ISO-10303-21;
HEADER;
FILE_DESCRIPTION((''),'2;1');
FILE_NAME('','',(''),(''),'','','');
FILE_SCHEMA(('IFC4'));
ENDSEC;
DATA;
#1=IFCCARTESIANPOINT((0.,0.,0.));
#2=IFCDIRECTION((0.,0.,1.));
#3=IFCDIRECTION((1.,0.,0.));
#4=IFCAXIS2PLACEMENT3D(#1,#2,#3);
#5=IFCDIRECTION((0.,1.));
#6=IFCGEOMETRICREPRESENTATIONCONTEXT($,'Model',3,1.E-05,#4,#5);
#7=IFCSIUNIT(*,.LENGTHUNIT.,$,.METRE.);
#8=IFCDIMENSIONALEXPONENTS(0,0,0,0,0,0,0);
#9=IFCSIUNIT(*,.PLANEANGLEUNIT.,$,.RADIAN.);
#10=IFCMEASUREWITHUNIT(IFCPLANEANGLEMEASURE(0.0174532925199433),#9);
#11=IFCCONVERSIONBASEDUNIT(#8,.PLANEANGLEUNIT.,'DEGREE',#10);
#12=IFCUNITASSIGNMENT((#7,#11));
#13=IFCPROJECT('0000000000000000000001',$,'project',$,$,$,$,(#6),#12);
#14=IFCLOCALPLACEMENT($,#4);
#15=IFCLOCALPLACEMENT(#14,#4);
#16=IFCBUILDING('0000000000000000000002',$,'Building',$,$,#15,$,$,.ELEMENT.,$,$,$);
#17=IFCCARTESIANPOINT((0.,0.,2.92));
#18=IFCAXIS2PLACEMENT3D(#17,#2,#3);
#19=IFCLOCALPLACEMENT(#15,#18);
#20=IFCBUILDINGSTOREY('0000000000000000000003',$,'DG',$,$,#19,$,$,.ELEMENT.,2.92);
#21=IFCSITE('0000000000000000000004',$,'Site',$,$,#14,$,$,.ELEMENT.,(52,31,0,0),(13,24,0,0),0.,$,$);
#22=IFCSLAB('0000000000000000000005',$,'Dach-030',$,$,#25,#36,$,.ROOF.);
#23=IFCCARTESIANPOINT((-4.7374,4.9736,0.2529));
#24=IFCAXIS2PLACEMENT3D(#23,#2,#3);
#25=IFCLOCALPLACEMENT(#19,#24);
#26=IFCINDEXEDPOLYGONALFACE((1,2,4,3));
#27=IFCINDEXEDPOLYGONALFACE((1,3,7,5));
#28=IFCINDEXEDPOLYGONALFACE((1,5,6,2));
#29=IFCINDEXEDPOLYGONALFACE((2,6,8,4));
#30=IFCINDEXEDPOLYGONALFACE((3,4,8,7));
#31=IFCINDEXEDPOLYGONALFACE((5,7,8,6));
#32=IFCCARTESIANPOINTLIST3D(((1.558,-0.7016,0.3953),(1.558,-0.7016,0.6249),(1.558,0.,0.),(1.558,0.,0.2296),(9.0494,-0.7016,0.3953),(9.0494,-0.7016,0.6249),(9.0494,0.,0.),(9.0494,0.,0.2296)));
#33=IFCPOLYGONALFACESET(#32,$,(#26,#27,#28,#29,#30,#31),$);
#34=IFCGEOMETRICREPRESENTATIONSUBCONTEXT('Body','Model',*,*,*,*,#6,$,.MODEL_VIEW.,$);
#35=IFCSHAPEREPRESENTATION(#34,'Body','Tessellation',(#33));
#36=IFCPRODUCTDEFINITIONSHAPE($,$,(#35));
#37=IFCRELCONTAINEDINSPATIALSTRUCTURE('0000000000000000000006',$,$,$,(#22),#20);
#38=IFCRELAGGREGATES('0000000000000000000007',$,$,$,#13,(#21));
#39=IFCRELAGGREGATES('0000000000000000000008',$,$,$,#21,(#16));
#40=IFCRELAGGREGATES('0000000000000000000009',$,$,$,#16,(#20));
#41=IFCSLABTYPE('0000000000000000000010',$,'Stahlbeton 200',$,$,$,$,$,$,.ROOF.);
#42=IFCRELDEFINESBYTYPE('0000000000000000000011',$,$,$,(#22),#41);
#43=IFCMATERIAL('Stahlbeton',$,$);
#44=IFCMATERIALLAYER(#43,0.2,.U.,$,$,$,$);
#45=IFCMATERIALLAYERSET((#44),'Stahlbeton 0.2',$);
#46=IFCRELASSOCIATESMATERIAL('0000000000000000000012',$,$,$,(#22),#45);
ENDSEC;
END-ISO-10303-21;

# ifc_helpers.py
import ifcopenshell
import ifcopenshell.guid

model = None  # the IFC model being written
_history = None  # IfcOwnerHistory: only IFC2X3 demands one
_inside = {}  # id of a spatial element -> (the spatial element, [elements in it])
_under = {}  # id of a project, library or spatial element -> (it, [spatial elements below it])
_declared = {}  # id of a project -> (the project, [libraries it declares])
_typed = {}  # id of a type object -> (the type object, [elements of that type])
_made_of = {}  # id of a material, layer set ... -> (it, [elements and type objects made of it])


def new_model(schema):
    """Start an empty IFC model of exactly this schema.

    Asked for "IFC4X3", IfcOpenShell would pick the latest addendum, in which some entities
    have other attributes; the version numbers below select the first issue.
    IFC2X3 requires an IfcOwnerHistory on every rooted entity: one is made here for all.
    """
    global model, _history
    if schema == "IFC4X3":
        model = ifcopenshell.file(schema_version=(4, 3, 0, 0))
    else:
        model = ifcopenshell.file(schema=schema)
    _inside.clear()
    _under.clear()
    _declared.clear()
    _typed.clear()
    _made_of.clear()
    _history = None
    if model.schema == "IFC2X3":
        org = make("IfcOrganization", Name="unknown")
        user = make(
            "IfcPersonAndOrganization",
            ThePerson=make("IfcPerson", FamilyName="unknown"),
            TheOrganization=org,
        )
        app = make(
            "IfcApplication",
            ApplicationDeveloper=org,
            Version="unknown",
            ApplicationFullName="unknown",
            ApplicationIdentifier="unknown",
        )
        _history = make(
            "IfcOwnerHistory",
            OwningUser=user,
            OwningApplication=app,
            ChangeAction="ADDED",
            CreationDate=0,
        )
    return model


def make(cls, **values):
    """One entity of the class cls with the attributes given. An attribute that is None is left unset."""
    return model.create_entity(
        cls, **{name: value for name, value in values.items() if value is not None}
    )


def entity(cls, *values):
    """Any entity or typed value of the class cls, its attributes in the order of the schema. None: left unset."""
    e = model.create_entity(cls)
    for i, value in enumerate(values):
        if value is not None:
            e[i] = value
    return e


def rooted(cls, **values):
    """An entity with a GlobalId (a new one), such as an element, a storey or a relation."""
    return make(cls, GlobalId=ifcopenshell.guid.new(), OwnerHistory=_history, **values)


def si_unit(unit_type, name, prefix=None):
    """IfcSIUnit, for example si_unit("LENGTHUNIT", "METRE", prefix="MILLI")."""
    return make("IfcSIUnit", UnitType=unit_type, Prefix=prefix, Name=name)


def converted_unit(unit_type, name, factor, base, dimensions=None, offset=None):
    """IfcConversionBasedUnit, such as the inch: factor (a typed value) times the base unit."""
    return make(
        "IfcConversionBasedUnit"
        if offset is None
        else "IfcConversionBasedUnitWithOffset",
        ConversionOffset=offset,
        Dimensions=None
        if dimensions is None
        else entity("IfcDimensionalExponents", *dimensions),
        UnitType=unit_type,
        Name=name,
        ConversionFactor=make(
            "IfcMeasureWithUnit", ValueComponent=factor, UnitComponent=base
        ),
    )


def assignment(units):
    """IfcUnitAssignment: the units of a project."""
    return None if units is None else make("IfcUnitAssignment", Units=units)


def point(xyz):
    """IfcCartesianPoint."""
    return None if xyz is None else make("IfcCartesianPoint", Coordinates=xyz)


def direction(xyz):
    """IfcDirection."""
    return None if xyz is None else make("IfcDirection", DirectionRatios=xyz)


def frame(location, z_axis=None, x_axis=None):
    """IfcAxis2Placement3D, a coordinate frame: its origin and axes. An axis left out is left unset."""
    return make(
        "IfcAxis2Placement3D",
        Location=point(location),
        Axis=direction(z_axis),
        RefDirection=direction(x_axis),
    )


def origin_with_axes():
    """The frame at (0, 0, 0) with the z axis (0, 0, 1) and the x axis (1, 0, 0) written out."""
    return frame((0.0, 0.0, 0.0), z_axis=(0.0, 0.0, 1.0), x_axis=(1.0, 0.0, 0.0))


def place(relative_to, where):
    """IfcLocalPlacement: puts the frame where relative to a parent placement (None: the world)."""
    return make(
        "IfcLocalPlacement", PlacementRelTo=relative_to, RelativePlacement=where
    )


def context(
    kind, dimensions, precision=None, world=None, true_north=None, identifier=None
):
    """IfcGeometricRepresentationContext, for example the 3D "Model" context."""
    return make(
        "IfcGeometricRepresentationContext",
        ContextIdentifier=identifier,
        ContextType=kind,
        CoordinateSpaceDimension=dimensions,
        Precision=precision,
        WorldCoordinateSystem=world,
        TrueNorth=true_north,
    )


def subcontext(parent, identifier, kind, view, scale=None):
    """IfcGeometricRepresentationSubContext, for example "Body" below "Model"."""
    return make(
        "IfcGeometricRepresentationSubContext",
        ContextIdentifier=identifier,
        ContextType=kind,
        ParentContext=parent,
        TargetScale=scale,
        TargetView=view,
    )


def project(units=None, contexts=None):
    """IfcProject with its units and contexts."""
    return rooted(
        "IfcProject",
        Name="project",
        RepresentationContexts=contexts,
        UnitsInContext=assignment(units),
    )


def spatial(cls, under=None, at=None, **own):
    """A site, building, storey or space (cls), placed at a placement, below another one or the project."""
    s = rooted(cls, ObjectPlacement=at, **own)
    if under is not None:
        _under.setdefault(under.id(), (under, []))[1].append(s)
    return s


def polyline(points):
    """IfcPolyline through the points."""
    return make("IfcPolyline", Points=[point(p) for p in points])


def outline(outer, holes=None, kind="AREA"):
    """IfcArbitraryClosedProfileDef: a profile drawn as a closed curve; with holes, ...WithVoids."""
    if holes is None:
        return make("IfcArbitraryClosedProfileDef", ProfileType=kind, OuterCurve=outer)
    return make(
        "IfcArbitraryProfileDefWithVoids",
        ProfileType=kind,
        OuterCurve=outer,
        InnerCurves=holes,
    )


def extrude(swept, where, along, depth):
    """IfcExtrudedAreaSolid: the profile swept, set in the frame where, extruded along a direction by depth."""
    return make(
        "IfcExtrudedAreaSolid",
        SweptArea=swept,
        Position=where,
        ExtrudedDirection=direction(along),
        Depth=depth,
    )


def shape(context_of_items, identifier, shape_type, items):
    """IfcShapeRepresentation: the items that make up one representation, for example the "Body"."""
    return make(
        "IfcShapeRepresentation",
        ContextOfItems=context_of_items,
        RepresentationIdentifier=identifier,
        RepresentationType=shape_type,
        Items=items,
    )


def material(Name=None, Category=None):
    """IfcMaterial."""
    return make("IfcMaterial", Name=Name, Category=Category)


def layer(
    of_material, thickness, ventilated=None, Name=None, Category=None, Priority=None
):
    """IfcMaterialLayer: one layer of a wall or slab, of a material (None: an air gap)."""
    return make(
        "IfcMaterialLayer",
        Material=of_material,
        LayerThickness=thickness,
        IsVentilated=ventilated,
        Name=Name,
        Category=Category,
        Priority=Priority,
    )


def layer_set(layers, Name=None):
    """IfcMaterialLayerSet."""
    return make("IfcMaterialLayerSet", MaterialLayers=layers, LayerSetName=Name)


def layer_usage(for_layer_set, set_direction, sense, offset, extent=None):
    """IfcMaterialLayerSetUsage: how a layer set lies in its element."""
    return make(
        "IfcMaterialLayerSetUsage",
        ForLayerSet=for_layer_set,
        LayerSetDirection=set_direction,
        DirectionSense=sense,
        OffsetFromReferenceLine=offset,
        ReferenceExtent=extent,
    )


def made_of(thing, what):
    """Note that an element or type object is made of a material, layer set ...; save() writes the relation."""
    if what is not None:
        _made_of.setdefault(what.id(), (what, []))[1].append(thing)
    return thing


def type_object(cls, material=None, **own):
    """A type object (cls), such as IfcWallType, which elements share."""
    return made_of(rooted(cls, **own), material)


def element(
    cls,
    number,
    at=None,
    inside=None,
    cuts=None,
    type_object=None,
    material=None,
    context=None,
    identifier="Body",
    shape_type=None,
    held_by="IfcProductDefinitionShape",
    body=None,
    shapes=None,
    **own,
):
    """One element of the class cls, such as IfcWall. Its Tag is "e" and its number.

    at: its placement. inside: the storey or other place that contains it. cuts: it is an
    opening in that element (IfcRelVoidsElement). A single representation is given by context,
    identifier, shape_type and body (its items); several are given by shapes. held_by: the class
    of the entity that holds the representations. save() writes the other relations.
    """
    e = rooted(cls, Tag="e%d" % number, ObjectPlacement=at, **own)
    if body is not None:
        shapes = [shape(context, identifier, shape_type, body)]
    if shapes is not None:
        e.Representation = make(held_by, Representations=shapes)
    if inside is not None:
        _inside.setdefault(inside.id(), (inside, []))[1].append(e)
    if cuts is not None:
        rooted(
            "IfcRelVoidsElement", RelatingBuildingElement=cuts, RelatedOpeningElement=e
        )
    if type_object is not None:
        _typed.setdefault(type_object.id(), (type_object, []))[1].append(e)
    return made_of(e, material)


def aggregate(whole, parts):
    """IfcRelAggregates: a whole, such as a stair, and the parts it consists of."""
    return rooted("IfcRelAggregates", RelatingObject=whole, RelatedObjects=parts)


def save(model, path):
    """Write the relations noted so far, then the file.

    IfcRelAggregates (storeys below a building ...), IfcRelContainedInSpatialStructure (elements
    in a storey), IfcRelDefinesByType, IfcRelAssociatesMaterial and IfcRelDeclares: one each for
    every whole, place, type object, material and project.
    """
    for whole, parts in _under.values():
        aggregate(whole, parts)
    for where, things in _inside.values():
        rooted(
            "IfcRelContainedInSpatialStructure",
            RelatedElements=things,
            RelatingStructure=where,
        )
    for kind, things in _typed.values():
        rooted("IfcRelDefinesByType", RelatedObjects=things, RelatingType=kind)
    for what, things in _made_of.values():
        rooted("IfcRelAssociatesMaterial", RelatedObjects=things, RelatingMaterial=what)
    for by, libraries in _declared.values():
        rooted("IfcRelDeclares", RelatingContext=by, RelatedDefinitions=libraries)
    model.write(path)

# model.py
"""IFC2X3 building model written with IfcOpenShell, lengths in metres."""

from ifc_helpers import new_model, entity, si_unit, converted_unit, direction, frame, origin_with_axes, place, context, subcontext, project, spatial, polyline, outline, extrude, material, layer, layer_set, layer_usage, type_object, element, save


model = new_model("IFC2X3")

# Units and contexts
model_context = context("Model", 3, precision=1e-05, world=origin_with_axes(), true_north=direction((0.0, 1.0)))
body_context = subcontext(model_context, "Body", "Model", "MODEL_VIEW")
ifc_project = project(units=[si_unit("LENGTHUNIT", "METRE"), converted_unit("PLANEANGLEUNIT", "DEGREE", entity("IfcPlaneAngleMeasure", 0.0174532925199433), si_unit("PLANEANGLEUNIT", "RADIAN"), dimensions=[0, 0, 0, 0, 0, 0, 0])], contexts=[model_context])

# Site, building, storey
site_placement = place(None, origin_with_axes())
site = spatial("IfcSite", under=ifc_project, at=site_placement, Name="Site", CompositionType="ELEMENT", RefLatitude=(52, 31, 0, 0), RefLongitude=(13, 24, 0, 0), RefElevation=0.0)
building_placement = place(site_placement, origin_with_axes())
building = spatial("IfcBuilding", under=site, at=building_placement, Name="Building", CompositionType="ELEMENT")
storey_placement = place(building_placement, frame((0.0, 0.0, 2.92), z_axis=(0.0, 0.0, 1.0), x_axis=(1.0, 0.0, 0.0)))
storey = spatial("IfcBuildingStorey", under=building, at=storey_placement, Name="DG", CompositionType="ELEMENT", Elevation=2.92)

# Slab
ifc_material = material(Name="Stahlbeton")
ifc_layer = layer(ifc_material, 0.2, ventilated="UNKNOWN")
ifc_layer_set = layer_set([ifc_layer], Name="Stahlbeton 0.2")
ifc_layer_usage_1 = layer_usage(ifc_layer_set, "AXIS3", "NEGATIVE", 0.2)
slab_type_1 = type_object("IfcSlabType", Name="Stahlbeton 200", PredefinedType="ROOF")
slab_1_placement = place(storey_placement, frame((-4.7374, 4.9736, 0.2529), z_axis=(0.0, 0.0, 1.0), x_axis=(1.0, 0.0, 0.0)))
element("IfcSlab", 1, at=slab_1_placement, inside=storey, type_object=slab_type_1, material=ifc_layer_usage_1, Name="Dach-030", PredefinedType="ROOF", context=body_context, shape_type="SweptSolid", body=[
    extrude(outline(polyline([(9.0494, 0.0), (1.558, 0.0), (1.558, -0.8053), (9.0494, -0.8053), (9.0494, 0.0)])), frame((0.0, 0.0, 0.0), z_axis=(0.0, 0.490904, 0.871214), x_axis=(1.0, 0.0, 0.0)), (0.0, -0.490904, 0.871214), 0.2296),
])

save(model, "model.ifc")
